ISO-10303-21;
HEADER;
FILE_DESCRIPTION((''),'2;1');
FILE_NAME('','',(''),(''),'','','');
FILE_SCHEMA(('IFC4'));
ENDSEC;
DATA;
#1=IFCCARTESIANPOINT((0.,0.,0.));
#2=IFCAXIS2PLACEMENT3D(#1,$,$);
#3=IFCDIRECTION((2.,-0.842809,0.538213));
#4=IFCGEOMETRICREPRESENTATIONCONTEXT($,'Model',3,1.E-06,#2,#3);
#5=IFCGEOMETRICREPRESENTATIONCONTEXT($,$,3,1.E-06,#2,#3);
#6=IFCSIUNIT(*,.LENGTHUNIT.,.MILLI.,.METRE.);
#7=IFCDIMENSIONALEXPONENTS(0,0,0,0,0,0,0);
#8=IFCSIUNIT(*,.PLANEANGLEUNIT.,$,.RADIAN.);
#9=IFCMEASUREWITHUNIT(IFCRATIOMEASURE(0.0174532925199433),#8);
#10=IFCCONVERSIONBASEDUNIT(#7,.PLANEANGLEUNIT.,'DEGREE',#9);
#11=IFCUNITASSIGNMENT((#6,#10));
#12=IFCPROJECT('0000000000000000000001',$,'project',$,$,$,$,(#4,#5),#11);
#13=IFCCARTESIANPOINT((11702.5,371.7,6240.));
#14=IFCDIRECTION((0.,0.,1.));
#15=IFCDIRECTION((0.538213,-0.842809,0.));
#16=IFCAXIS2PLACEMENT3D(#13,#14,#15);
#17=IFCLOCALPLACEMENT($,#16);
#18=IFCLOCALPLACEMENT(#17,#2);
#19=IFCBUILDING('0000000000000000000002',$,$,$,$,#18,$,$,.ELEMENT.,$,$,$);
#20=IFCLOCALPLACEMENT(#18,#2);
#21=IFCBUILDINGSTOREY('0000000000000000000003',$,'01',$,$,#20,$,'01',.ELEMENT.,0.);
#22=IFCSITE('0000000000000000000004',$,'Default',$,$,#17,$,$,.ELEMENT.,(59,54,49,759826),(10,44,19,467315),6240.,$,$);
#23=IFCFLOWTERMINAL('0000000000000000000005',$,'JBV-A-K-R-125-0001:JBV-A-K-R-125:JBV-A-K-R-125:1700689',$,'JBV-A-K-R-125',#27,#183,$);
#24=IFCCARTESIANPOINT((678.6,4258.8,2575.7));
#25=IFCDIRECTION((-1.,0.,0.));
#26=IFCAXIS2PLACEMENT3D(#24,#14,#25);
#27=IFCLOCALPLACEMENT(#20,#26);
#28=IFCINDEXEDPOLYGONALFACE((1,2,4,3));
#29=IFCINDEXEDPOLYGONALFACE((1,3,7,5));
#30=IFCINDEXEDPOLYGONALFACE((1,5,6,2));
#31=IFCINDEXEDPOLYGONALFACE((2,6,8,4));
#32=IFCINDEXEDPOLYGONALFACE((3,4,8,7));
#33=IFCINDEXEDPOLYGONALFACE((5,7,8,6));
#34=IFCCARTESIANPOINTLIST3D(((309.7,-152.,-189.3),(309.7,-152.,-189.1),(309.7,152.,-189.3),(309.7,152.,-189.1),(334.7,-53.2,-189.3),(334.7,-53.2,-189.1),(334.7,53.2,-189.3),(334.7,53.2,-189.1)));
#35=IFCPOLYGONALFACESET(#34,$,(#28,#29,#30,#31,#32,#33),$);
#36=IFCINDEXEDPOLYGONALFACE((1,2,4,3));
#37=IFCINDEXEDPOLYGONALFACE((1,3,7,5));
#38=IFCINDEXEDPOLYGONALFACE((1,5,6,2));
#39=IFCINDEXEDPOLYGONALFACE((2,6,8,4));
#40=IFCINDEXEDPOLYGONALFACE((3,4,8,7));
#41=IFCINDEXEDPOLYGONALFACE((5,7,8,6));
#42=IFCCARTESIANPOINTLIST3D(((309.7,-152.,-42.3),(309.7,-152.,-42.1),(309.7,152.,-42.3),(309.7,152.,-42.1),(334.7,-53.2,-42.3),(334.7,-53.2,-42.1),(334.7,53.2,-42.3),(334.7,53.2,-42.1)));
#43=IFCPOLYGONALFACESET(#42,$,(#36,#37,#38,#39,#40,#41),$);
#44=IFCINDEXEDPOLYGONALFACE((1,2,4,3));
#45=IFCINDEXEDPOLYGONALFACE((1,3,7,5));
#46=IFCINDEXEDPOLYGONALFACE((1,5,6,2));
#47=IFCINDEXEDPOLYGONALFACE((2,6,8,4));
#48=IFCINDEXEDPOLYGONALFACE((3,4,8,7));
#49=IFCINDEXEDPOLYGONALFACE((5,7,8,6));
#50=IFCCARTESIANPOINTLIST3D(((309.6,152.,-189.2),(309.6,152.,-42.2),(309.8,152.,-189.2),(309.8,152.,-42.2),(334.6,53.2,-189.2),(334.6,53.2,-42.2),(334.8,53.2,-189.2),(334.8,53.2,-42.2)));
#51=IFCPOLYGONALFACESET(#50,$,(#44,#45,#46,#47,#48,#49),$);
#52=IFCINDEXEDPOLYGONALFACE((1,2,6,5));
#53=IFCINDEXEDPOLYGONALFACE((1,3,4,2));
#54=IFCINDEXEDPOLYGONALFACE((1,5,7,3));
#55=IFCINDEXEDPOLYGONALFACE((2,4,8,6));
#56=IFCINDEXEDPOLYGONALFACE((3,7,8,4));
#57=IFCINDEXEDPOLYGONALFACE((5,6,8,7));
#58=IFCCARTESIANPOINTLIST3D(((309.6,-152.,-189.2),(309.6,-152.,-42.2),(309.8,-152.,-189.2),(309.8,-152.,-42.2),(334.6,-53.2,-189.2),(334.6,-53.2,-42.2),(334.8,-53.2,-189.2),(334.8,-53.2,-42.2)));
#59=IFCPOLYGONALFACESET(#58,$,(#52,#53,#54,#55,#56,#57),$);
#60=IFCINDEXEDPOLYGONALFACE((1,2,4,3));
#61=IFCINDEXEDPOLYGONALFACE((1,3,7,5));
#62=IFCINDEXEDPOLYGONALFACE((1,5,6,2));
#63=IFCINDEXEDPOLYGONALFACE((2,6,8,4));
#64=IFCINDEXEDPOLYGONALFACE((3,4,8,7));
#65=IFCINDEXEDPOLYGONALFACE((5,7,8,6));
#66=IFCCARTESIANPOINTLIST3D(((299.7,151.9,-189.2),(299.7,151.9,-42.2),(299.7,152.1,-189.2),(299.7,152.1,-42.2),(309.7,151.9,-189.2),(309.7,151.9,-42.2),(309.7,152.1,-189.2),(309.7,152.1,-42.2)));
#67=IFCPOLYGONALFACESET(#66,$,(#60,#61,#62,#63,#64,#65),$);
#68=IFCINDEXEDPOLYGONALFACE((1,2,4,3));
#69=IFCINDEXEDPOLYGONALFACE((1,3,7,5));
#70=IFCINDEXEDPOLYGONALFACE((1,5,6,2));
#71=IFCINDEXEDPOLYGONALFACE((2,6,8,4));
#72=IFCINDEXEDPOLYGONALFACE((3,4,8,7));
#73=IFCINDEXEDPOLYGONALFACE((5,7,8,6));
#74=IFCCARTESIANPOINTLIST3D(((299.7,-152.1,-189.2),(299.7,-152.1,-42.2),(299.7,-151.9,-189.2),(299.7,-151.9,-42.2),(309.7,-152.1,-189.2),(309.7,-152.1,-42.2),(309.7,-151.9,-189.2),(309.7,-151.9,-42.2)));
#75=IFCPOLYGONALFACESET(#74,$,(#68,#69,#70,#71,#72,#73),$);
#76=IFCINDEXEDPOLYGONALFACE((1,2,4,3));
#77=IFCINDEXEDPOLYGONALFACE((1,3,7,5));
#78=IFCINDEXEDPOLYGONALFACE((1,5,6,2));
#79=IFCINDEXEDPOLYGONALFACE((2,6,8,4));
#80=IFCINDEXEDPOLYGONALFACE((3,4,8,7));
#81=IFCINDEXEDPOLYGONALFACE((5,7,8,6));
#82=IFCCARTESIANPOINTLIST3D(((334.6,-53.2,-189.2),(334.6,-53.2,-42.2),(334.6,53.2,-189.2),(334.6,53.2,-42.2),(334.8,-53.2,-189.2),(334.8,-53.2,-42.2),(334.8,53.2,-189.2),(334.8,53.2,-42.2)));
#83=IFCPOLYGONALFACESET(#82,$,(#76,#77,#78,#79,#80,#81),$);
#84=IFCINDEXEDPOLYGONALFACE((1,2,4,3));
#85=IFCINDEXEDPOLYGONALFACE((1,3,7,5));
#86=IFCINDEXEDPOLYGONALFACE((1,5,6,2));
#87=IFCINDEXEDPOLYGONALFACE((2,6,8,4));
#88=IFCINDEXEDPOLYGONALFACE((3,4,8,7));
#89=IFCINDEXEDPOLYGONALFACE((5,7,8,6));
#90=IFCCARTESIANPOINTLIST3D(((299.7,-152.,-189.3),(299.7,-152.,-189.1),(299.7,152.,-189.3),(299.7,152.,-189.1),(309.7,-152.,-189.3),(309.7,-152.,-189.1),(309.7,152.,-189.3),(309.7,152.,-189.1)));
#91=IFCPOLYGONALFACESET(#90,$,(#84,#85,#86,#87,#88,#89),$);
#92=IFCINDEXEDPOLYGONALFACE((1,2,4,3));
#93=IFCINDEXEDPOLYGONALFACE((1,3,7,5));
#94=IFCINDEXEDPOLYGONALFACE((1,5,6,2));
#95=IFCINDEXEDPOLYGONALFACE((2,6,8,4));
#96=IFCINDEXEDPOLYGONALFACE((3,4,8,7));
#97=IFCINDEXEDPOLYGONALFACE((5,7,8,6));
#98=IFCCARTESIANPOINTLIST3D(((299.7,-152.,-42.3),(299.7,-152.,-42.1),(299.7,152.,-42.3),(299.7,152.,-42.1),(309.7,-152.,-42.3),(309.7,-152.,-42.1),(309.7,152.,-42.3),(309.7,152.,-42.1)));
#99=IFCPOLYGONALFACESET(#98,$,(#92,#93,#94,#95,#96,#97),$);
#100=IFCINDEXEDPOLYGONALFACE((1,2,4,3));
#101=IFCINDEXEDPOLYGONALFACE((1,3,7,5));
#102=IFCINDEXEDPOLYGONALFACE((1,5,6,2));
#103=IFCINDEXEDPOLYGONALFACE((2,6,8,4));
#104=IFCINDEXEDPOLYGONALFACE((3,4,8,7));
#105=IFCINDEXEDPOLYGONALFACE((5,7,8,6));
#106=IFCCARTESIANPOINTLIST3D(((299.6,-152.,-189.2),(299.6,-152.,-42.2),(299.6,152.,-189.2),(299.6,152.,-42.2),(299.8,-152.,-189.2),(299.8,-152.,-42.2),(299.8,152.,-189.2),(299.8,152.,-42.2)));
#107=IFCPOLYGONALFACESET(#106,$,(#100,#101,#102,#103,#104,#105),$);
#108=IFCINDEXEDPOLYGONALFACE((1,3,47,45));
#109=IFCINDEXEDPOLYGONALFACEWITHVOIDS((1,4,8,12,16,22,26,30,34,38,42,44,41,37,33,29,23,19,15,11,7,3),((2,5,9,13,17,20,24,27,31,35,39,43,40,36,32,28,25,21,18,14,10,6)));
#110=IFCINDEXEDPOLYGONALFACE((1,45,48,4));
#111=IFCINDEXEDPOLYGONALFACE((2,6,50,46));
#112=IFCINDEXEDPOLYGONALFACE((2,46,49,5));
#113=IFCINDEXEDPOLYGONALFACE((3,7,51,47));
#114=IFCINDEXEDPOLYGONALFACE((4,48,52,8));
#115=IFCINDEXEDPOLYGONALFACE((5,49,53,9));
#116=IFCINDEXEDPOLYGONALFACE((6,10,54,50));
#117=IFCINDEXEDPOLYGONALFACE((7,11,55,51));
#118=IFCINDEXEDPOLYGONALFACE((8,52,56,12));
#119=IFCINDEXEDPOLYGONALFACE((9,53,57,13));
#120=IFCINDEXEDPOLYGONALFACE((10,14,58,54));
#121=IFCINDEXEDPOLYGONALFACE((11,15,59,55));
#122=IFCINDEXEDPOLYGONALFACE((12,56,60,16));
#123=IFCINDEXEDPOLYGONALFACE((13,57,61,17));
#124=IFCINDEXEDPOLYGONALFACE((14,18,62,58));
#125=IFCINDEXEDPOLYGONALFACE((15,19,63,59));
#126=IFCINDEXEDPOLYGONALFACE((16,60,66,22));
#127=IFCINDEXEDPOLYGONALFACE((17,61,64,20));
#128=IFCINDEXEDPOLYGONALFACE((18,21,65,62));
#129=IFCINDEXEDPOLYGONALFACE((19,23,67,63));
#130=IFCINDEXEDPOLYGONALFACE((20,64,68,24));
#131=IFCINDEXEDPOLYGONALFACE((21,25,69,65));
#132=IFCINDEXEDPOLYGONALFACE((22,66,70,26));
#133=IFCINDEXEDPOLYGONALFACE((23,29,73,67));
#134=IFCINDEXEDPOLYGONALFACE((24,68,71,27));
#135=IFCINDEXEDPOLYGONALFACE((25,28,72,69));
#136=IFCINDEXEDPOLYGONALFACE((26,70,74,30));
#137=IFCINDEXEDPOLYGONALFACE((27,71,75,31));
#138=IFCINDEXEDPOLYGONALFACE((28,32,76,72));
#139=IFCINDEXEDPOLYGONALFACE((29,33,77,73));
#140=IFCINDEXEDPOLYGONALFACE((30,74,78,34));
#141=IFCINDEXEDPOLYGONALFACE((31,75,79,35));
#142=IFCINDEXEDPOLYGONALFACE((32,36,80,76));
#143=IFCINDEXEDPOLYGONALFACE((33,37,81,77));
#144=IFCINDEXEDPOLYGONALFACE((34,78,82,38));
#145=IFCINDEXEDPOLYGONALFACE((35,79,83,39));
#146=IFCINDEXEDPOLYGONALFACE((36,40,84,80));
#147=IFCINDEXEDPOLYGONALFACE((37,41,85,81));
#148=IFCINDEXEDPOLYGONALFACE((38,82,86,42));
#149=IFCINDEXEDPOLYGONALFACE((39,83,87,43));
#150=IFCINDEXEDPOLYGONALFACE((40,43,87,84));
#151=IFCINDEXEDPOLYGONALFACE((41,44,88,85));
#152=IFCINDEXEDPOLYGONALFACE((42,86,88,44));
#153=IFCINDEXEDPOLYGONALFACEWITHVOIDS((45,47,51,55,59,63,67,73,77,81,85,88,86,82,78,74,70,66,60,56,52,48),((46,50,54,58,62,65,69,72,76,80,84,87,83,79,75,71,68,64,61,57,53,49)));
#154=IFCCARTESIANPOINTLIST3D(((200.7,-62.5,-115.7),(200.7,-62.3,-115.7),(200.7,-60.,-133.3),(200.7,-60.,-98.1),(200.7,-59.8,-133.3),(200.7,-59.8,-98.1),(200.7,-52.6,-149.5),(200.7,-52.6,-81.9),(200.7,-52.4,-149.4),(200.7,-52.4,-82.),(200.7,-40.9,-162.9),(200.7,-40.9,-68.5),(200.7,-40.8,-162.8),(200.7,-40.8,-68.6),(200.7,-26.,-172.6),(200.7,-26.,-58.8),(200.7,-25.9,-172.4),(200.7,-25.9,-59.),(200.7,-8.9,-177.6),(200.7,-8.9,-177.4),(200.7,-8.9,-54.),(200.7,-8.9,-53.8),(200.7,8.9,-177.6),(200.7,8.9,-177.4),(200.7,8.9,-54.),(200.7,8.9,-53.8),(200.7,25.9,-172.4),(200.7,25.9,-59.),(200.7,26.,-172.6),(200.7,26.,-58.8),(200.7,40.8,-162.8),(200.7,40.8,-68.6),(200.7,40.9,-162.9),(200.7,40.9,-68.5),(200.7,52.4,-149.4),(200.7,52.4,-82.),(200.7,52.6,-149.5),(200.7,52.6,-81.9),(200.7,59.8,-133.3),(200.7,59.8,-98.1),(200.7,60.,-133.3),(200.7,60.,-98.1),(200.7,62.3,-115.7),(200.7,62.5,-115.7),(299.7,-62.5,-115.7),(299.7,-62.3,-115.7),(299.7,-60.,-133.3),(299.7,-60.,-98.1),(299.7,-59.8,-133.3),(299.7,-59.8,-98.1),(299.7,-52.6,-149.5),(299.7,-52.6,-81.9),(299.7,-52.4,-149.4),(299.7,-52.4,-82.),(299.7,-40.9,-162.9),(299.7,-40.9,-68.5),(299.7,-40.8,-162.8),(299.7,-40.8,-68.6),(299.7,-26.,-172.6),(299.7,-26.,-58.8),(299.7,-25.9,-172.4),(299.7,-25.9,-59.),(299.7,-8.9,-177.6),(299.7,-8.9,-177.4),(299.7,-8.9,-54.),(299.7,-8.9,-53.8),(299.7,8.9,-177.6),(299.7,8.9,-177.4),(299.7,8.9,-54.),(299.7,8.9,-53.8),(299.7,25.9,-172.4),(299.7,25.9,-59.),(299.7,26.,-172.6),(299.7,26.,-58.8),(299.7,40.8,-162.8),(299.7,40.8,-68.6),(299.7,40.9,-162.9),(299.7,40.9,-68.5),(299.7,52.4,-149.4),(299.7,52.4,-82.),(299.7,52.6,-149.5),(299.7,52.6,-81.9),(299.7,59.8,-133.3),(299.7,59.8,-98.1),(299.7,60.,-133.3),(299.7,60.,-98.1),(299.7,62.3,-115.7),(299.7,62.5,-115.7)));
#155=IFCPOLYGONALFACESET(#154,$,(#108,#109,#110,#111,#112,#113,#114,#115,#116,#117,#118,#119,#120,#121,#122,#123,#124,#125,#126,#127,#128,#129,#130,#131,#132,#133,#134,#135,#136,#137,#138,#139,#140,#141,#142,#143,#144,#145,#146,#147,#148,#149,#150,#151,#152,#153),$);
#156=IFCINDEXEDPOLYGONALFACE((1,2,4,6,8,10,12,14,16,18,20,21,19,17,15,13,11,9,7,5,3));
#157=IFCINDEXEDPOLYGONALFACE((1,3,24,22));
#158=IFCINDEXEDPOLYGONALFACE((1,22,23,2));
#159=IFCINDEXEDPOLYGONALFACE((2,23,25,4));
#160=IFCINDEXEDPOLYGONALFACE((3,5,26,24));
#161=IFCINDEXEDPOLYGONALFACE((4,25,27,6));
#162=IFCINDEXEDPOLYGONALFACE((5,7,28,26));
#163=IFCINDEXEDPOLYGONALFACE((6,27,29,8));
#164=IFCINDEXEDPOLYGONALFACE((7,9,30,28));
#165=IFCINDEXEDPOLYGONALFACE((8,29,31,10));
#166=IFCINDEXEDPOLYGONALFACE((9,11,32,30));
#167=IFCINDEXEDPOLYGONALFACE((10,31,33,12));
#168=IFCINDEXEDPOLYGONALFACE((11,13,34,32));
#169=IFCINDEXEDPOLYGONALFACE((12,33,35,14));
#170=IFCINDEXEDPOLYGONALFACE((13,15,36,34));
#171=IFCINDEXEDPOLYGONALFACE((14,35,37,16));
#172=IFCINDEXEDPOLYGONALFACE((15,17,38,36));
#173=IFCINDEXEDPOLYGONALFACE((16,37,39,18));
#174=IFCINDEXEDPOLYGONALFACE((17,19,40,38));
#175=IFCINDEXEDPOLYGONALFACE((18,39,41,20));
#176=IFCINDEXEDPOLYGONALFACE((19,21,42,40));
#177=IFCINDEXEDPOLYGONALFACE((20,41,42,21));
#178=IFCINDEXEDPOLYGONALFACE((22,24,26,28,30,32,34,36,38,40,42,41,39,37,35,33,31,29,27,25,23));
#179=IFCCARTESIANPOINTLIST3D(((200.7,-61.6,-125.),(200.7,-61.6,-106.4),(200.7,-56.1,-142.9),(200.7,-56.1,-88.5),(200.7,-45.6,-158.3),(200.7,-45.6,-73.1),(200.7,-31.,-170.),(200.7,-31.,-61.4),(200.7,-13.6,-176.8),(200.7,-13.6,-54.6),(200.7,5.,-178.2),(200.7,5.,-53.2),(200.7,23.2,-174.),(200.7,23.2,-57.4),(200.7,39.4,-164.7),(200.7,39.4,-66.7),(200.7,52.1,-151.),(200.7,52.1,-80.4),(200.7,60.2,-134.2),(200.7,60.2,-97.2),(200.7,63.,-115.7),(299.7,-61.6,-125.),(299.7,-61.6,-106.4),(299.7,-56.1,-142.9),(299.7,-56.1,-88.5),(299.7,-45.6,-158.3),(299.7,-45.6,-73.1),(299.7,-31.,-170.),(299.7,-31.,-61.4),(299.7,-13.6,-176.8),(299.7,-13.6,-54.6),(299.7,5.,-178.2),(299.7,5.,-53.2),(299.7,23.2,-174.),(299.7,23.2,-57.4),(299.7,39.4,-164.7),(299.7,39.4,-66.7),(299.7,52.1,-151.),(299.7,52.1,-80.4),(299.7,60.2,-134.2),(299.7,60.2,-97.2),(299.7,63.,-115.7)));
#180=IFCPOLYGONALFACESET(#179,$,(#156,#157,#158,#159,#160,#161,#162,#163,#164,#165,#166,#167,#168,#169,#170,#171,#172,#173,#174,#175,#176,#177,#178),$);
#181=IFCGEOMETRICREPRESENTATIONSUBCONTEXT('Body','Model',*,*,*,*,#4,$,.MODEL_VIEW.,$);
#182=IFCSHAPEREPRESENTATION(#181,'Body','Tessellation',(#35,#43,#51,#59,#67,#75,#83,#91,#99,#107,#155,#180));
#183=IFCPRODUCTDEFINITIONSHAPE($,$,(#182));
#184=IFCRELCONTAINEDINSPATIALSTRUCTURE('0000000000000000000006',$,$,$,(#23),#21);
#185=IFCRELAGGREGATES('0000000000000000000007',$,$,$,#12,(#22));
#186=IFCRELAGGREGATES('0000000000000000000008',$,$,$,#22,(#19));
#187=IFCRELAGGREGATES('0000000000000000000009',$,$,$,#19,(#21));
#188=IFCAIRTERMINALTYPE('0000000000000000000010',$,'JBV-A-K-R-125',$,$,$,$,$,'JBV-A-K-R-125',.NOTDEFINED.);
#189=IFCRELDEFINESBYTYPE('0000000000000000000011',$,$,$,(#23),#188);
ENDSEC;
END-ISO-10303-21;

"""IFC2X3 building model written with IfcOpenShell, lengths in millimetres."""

from ifc_helpers import new_model, entity, si_unit, converted_unit, direction, frame, frame_2d, origin, origin_2d_with_axis, place, context, subcontext, project, spatial, polyline, circle_curve, parameter, trimmed, segment, composite_curve, rectangle, circle, outline, extrude, source, transform, mapped, type_object, type_shapes, element, save


model = new_model("IFC2X3")

# Units and contexts
model_context = context("Model", 3, precision=1e-06, world=origin(), true_north=direction((2.0, -0.842809, 0.538213)))
context_of_model = context(None, 3, precision=1e-06, world=origin(), true_north=direction((2.0, -0.842809, 0.538213)))
body_context = subcontext(model_context, "Body", "Model", "MODEL_VIEW")
ifc_project = project(units=[si_unit("LENGTHUNIT", "METRE", prefix="MILLI"), converted_unit("PLANEANGLEUNIT", "DEGREE", entity("IfcRatioMeasure", 0.0174532925199433), si_unit("PLANEANGLEUNIT", "RADIAN"), dimensions=[0, 0, 0, 0, 0, 0, 0])], contexts=[model_context, context_of_model])

# Site, building, storey
site_placement = place(None, frame((11702.5, 371.7, 6240.0), z_axis=(0.0, 0.0, 1.0), x_axis=(0.538213, -0.842809, 0.0)))
site = spatial("IfcSite", under=ifc_project, at=site_placement, Name="Default", CompositionType="ELEMENT", RefLatitude=(59, 54, 49, 759826), RefLongitude=(10, 44, 19, 467315), RefElevation=6240.0)
building_placement = place(site_placement, origin())
building = spatial("IfcBuilding", under=site, at=building_placement, CompositionType="ELEMENT")
storey_placement = place(building_placement, origin())
storey = spatial("IfcBuildingStorey", under=building, at=storey_placement, Name="01", LongName="01", CompositionType="ELEMENT", Elevation=0.0)

# Flow terminal
air_terminal_type_1 = type_object("IfcAirTerminalType", Name="JBV-A-K-R-125", ElementType="JBV-A-K-R-125", PredefinedType="NOTDEFINED")
shared_shape_1 = source(origin(), body_context, "Body", "SweptSolid", [
    extrude(outline(polyline([(-152.0, -12.5), (152.0, -12.5), (53.2, 12.5), (-53.2, 12.5), (-152.0, -12.5)])), frame((322.2, 0.0, -189.3), z_axis=(0.0, 0.0, 1.0), x_axis=(0.0, -1.0, 0.0)), (0.0, 0.0, 1.0), 0.2),
    extrude(outline(polyline([(-152.0, -12.5), (152.0, -12.5), (53.2, 12.5), (-53.2, 12.5), (-152.0, -12.5)])), frame((322.2, 0.0, -42.3), z_axis=(0.0, 0.0, 1.0), x_axis=(0.0, -1.0, 0.0)), (0.0, 0.0, 1.0), 0.2),
    extrude(rectangle(XDim=0.2, YDim=101.9, at=frame_2d((0.0, 0.0), x_axis=(1.0, 0.0))), frame((322.2, 102.6, -189.2), z_axis=(0.0, 0.0, 1.0), x_axis=(0.969446, 0.245305, 0.0)), (0.0, 0.0, 1.0), 147.0),
    extrude(rectangle(XDim=0.2, YDim=101.9, at=frame_2d((0.0, 0.0), x_axis=(1.0, 0.0))), frame((322.2, -102.6, -189.2), z_axis=(0.0, 0.0, 1.0), x_axis=(-0.969446, 0.245305, 0.0)), (0.0, 0.0, 1.0), 147.0),
    extrude(rectangle(XDim=0.2, YDim=10.0, at=frame_2d((0.0, 0.0), x_axis=(1.0, 0.0))), frame((304.7, 152.0, -189.2), z_axis=(0.0, 0.0, 1.0), x_axis=(0.0, 1.0, 0.0)), (0.0, 0.0, 1.0), 147.0),
    extrude(rectangle(XDim=0.2, YDim=10.0, at=frame_2d((0.0, 0.0), x_axis=(1.0, 0.0))), frame((304.7, -152.0, -189.2), z_axis=(0.0, 0.0, 1.0), x_axis=(0.0, 1.0, 0.0)), (0.0, 0.0, 1.0), 147.0),
    extrude(rectangle(XDim=0.2, YDim=106.4, at=frame_2d((0.0, 0.0), x_axis=(1.0, 0.0))), frame((334.7, 0.0, -189.2)), (0.0, 0.0, 1.0), 147.0),
    extrude(rectangle(XDim=304.0, YDim=10.0, at=frame_2d((0.0, 0.0), x_axis=(1.0, 0.0))), frame((304.7, 0.0, -189.3), z_axis=(0.0, 0.0, 1.0), x_axis=(0.0, -1.0, 0.0)), (0.0, 0.0, 1.0), 0.2),
    extrude(rectangle(XDim=304.0, YDim=10.0, at=frame_2d((0.0, 0.0), x_axis=(1.0, 0.0))), frame((304.7, 0.0, -42.3), z_axis=(0.0, 0.0, 1.0), x_axis=(0.0, -1.0, 0.0)), (0.0, 0.0, 1.0), 0.2),
    extrude(rectangle(XDim=0.2, YDim=304.0, at=frame_2d((0.0, 0.0), x_axis=(1.0, 0.0))), frame((299.7, 0.0, -189.2)), (0.0, 0.0, 1.0), 147.0),
    extrude(outline(composite_curve([segment(trimmed(circle_curve(origin_2d_with_axis(), 62.5), [parameter(0.0)], [parameter(180.0)], True, "PARAMETER"), True, "CONTINUOUS"), segment(trimmed(circle_curve(origin_2d_with_axis(), 62.5), [parameter(180.0)], [parameter(360.0)], True, "PARAMETER"), True, "CONTINUOUS")], self_intersect=False), holes=[composite_curve([segment(trimmed(circle_curve(origin_2d_with_axis(), 62.3), [parameter(180.0)], [parameter(360.0)], True, "PARAMETER"), False, "CONTINUOUS"), segment(trimmed(circle_curve(origin_2d_with_axis(), 62.3), [parameter(0.0)], [parameter(180.0)], True, "PARAMETER"), False, "CONTINUOUS")], self_intersect=False)]), frame((200.7, 0.0, -115.7), z_axis=(1.0, 0.0, 0.0), x_axis=(0.0, 1.0, 0.0)), (0.0, 0.0, 1.0), 99.0),
    extrude(circle(Radius=62.6, at=frame_2d((0.0, 0.0), x_axis=(1.0, 0.0))), frame((200.7, 0.3, -115.7), z_axis=(1.0, 0.0, 0.0), x_axis=(0.0, 1.0, 0.0)), (0.0, 0.0, 1.0), 99.0),
])
type_shapes(air_terminal_type_1, [shared_shape_1])
flow_terminal_1_placement = place(storey_placement, frame((678.6, 4258.8, 2575.7), z_axis=(0.0, 0.0, 1.0), x_axis=(-1.0, 0.0, 0.0)))
element("IfcFlowTerminal", 1, at=flow_terminal_1_placement, inside=storey, type_object=air_terminal_type_1, Name="JBV-A-K-R-125-0001:JBV-A-K-R-125:JBV-A-K-R-125:1700689", ObjectType="JBV-A-K-R-125", context=body_context, shape_type="MappedRepresentation", body=[
    mapped(shared_shape_1, transform((0.0, 0.0, 0.0), scale=1.0)),
])

save(model, "model.ifc")
